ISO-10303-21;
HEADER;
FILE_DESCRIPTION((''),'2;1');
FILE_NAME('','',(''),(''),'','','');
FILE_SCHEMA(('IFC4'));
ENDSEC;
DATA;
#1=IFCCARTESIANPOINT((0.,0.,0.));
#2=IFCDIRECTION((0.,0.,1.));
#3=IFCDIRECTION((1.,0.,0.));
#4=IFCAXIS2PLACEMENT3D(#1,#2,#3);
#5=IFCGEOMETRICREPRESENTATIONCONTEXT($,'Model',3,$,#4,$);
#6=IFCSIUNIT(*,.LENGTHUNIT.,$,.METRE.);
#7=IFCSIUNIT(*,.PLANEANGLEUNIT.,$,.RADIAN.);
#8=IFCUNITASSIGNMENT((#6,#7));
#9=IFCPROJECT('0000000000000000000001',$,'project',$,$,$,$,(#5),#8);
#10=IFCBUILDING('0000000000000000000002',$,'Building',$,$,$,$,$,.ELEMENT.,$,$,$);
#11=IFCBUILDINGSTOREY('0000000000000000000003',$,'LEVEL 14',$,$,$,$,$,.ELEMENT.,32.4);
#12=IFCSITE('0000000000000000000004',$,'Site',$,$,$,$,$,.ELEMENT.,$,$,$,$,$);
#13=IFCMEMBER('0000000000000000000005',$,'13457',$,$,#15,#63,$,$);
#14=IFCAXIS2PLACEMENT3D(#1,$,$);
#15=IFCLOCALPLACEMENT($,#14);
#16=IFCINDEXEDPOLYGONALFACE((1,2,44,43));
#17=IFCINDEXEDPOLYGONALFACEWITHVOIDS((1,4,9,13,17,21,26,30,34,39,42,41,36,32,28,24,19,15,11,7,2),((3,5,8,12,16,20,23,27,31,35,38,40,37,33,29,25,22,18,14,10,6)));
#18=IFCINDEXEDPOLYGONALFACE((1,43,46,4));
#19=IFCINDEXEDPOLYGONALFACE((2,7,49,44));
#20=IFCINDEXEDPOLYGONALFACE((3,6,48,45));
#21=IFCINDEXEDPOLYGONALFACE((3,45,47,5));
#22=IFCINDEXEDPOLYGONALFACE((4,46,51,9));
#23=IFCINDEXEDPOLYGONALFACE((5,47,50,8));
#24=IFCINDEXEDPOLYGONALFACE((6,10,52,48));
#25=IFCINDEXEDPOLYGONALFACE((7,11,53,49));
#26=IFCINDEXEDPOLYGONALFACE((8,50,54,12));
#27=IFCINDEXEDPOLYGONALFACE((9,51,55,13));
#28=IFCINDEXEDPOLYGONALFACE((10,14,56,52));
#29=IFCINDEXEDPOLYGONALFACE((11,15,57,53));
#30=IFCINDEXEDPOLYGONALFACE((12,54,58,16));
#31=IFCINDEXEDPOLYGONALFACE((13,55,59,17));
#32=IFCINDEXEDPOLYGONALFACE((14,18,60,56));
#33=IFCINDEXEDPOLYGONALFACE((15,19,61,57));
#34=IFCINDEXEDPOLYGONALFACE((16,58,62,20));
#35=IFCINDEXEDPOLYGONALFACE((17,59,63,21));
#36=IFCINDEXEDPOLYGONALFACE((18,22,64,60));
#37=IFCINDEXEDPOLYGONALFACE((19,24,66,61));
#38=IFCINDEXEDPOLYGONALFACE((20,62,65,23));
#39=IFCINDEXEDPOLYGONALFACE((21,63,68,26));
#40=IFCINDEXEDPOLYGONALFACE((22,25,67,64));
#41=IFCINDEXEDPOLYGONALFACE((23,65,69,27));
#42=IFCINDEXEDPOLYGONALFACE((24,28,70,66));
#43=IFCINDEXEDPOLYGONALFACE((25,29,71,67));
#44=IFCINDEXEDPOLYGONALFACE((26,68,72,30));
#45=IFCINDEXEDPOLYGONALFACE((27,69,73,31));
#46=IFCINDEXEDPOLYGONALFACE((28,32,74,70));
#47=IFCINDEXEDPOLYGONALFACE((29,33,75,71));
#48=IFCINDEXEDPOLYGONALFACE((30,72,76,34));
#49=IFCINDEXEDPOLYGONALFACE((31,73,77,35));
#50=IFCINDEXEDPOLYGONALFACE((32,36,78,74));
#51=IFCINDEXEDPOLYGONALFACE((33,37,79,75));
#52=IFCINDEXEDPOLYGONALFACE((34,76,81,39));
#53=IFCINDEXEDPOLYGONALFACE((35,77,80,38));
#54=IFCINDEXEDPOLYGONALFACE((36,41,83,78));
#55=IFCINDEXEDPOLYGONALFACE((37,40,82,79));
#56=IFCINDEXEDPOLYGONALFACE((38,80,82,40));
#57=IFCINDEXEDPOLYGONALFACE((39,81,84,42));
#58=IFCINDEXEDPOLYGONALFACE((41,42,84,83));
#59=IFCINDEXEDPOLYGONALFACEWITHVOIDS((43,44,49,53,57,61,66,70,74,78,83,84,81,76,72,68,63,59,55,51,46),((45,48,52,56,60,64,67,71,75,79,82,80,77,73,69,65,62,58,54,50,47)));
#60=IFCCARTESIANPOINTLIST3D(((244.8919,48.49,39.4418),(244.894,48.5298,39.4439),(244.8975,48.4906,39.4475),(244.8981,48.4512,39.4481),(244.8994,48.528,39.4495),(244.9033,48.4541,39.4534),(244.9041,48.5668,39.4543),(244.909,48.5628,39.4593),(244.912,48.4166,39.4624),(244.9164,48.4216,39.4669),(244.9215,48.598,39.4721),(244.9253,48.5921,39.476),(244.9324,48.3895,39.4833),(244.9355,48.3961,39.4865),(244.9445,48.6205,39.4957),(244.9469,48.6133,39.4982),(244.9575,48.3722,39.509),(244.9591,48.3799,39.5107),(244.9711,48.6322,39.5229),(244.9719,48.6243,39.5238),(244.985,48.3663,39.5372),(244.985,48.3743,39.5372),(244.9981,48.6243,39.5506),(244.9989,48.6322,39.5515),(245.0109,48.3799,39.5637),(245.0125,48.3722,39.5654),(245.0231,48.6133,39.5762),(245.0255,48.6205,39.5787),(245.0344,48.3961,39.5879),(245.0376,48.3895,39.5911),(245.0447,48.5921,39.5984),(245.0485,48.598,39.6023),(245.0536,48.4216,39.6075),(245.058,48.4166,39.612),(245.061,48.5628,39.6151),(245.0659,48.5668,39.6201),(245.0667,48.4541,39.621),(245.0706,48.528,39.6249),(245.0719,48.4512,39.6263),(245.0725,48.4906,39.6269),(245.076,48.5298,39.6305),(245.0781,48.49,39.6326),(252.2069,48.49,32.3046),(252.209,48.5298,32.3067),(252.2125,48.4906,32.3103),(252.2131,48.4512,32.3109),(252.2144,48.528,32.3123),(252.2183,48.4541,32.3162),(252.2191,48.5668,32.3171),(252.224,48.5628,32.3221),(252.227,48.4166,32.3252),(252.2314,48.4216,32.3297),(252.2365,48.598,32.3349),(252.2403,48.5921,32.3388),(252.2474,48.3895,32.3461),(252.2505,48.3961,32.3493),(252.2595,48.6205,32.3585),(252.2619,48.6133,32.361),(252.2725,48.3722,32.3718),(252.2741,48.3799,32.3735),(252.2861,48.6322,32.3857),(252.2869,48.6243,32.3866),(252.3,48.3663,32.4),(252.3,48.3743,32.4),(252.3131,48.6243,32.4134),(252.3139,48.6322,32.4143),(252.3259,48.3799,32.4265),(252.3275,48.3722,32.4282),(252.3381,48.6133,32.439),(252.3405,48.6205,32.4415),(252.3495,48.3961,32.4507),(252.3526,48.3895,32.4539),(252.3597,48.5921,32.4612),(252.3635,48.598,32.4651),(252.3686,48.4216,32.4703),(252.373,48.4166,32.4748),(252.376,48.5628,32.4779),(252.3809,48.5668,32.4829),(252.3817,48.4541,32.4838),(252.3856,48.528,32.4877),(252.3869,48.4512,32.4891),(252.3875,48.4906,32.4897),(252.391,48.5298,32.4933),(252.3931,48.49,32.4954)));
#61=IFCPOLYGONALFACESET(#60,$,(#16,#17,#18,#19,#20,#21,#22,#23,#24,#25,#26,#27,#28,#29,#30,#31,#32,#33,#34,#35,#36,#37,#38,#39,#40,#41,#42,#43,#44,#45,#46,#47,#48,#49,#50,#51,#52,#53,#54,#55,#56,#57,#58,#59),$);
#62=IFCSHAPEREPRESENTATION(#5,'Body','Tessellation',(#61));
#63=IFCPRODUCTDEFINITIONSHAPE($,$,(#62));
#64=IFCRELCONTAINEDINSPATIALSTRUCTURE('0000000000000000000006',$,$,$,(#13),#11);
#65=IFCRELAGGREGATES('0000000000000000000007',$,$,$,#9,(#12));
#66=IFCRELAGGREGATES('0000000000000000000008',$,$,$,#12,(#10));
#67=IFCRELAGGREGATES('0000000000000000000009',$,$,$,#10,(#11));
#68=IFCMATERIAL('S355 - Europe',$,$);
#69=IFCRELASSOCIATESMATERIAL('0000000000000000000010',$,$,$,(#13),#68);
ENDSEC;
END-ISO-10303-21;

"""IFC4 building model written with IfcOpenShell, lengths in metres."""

from ifc_helpers import new_model, si_unit, frame, origin_with_axes, origin_2d_with_axis, place, context, project, spatial, hollow_circle, extrude, material, material_profile, profile_set, profile_usage, element, save


model = new_model("IFC4")

# Units and contexts
model_context = context("Model", 3, world=origin_with_axes())
ifc_project = project(units=[si_unit("LENGTHUNIT", "METRE"), si_unit("PLANEANGLEUNIT", "RADIAN")], contexts=[model_context])

# Site, building, storey
site = spatial("IfcSite", under=ifc_project, Name="Site", CompositionType="ELEMENT")
building = spatial("IfcBuilding", under=site, Name="Building", CompositionType="ELEMENT")
storey = spatial("IfcBuildingStorey", under=building, Name="LEVEL 14", CompositionType="ELEMENT", Elevation=32.4)

# Shared definitions
ifc_material = material(Name="S355 - Europe")

# Member
ifc_material_profile_1 = material_profile(ifc_material, hollow_circle(Radius=0.1337, WallThickness=0.008, at=origin_2d_with_axis()))
ifc_profile_set_1 = profile_set([ifc_material_profile_1])
ifc_profile_usage_1 = profile_usage(ifc_profile_set_1, cardinal=10)
member_1_placement = place(None, frame((252.3, 48.5, 32.4), z_axis=(-0.715752, 0.0, 0.698355), x_axis=(0.0, -1.0, 0.0)))
element("IfcMember", 1, at=member_1_placement, inside=storey, material=ifc_profile_usage_1, Name="13457", context=model_context, shape_type="SweptSolid", body=[
    extrude(hollow_circle(Radius=0.1337, WallThickness=0.008, at=origin_2d_with_axis()), origin_with_axes(), (0.0, 0.0, 1.0), 10.22),
])

save(model, "model.ifc")
